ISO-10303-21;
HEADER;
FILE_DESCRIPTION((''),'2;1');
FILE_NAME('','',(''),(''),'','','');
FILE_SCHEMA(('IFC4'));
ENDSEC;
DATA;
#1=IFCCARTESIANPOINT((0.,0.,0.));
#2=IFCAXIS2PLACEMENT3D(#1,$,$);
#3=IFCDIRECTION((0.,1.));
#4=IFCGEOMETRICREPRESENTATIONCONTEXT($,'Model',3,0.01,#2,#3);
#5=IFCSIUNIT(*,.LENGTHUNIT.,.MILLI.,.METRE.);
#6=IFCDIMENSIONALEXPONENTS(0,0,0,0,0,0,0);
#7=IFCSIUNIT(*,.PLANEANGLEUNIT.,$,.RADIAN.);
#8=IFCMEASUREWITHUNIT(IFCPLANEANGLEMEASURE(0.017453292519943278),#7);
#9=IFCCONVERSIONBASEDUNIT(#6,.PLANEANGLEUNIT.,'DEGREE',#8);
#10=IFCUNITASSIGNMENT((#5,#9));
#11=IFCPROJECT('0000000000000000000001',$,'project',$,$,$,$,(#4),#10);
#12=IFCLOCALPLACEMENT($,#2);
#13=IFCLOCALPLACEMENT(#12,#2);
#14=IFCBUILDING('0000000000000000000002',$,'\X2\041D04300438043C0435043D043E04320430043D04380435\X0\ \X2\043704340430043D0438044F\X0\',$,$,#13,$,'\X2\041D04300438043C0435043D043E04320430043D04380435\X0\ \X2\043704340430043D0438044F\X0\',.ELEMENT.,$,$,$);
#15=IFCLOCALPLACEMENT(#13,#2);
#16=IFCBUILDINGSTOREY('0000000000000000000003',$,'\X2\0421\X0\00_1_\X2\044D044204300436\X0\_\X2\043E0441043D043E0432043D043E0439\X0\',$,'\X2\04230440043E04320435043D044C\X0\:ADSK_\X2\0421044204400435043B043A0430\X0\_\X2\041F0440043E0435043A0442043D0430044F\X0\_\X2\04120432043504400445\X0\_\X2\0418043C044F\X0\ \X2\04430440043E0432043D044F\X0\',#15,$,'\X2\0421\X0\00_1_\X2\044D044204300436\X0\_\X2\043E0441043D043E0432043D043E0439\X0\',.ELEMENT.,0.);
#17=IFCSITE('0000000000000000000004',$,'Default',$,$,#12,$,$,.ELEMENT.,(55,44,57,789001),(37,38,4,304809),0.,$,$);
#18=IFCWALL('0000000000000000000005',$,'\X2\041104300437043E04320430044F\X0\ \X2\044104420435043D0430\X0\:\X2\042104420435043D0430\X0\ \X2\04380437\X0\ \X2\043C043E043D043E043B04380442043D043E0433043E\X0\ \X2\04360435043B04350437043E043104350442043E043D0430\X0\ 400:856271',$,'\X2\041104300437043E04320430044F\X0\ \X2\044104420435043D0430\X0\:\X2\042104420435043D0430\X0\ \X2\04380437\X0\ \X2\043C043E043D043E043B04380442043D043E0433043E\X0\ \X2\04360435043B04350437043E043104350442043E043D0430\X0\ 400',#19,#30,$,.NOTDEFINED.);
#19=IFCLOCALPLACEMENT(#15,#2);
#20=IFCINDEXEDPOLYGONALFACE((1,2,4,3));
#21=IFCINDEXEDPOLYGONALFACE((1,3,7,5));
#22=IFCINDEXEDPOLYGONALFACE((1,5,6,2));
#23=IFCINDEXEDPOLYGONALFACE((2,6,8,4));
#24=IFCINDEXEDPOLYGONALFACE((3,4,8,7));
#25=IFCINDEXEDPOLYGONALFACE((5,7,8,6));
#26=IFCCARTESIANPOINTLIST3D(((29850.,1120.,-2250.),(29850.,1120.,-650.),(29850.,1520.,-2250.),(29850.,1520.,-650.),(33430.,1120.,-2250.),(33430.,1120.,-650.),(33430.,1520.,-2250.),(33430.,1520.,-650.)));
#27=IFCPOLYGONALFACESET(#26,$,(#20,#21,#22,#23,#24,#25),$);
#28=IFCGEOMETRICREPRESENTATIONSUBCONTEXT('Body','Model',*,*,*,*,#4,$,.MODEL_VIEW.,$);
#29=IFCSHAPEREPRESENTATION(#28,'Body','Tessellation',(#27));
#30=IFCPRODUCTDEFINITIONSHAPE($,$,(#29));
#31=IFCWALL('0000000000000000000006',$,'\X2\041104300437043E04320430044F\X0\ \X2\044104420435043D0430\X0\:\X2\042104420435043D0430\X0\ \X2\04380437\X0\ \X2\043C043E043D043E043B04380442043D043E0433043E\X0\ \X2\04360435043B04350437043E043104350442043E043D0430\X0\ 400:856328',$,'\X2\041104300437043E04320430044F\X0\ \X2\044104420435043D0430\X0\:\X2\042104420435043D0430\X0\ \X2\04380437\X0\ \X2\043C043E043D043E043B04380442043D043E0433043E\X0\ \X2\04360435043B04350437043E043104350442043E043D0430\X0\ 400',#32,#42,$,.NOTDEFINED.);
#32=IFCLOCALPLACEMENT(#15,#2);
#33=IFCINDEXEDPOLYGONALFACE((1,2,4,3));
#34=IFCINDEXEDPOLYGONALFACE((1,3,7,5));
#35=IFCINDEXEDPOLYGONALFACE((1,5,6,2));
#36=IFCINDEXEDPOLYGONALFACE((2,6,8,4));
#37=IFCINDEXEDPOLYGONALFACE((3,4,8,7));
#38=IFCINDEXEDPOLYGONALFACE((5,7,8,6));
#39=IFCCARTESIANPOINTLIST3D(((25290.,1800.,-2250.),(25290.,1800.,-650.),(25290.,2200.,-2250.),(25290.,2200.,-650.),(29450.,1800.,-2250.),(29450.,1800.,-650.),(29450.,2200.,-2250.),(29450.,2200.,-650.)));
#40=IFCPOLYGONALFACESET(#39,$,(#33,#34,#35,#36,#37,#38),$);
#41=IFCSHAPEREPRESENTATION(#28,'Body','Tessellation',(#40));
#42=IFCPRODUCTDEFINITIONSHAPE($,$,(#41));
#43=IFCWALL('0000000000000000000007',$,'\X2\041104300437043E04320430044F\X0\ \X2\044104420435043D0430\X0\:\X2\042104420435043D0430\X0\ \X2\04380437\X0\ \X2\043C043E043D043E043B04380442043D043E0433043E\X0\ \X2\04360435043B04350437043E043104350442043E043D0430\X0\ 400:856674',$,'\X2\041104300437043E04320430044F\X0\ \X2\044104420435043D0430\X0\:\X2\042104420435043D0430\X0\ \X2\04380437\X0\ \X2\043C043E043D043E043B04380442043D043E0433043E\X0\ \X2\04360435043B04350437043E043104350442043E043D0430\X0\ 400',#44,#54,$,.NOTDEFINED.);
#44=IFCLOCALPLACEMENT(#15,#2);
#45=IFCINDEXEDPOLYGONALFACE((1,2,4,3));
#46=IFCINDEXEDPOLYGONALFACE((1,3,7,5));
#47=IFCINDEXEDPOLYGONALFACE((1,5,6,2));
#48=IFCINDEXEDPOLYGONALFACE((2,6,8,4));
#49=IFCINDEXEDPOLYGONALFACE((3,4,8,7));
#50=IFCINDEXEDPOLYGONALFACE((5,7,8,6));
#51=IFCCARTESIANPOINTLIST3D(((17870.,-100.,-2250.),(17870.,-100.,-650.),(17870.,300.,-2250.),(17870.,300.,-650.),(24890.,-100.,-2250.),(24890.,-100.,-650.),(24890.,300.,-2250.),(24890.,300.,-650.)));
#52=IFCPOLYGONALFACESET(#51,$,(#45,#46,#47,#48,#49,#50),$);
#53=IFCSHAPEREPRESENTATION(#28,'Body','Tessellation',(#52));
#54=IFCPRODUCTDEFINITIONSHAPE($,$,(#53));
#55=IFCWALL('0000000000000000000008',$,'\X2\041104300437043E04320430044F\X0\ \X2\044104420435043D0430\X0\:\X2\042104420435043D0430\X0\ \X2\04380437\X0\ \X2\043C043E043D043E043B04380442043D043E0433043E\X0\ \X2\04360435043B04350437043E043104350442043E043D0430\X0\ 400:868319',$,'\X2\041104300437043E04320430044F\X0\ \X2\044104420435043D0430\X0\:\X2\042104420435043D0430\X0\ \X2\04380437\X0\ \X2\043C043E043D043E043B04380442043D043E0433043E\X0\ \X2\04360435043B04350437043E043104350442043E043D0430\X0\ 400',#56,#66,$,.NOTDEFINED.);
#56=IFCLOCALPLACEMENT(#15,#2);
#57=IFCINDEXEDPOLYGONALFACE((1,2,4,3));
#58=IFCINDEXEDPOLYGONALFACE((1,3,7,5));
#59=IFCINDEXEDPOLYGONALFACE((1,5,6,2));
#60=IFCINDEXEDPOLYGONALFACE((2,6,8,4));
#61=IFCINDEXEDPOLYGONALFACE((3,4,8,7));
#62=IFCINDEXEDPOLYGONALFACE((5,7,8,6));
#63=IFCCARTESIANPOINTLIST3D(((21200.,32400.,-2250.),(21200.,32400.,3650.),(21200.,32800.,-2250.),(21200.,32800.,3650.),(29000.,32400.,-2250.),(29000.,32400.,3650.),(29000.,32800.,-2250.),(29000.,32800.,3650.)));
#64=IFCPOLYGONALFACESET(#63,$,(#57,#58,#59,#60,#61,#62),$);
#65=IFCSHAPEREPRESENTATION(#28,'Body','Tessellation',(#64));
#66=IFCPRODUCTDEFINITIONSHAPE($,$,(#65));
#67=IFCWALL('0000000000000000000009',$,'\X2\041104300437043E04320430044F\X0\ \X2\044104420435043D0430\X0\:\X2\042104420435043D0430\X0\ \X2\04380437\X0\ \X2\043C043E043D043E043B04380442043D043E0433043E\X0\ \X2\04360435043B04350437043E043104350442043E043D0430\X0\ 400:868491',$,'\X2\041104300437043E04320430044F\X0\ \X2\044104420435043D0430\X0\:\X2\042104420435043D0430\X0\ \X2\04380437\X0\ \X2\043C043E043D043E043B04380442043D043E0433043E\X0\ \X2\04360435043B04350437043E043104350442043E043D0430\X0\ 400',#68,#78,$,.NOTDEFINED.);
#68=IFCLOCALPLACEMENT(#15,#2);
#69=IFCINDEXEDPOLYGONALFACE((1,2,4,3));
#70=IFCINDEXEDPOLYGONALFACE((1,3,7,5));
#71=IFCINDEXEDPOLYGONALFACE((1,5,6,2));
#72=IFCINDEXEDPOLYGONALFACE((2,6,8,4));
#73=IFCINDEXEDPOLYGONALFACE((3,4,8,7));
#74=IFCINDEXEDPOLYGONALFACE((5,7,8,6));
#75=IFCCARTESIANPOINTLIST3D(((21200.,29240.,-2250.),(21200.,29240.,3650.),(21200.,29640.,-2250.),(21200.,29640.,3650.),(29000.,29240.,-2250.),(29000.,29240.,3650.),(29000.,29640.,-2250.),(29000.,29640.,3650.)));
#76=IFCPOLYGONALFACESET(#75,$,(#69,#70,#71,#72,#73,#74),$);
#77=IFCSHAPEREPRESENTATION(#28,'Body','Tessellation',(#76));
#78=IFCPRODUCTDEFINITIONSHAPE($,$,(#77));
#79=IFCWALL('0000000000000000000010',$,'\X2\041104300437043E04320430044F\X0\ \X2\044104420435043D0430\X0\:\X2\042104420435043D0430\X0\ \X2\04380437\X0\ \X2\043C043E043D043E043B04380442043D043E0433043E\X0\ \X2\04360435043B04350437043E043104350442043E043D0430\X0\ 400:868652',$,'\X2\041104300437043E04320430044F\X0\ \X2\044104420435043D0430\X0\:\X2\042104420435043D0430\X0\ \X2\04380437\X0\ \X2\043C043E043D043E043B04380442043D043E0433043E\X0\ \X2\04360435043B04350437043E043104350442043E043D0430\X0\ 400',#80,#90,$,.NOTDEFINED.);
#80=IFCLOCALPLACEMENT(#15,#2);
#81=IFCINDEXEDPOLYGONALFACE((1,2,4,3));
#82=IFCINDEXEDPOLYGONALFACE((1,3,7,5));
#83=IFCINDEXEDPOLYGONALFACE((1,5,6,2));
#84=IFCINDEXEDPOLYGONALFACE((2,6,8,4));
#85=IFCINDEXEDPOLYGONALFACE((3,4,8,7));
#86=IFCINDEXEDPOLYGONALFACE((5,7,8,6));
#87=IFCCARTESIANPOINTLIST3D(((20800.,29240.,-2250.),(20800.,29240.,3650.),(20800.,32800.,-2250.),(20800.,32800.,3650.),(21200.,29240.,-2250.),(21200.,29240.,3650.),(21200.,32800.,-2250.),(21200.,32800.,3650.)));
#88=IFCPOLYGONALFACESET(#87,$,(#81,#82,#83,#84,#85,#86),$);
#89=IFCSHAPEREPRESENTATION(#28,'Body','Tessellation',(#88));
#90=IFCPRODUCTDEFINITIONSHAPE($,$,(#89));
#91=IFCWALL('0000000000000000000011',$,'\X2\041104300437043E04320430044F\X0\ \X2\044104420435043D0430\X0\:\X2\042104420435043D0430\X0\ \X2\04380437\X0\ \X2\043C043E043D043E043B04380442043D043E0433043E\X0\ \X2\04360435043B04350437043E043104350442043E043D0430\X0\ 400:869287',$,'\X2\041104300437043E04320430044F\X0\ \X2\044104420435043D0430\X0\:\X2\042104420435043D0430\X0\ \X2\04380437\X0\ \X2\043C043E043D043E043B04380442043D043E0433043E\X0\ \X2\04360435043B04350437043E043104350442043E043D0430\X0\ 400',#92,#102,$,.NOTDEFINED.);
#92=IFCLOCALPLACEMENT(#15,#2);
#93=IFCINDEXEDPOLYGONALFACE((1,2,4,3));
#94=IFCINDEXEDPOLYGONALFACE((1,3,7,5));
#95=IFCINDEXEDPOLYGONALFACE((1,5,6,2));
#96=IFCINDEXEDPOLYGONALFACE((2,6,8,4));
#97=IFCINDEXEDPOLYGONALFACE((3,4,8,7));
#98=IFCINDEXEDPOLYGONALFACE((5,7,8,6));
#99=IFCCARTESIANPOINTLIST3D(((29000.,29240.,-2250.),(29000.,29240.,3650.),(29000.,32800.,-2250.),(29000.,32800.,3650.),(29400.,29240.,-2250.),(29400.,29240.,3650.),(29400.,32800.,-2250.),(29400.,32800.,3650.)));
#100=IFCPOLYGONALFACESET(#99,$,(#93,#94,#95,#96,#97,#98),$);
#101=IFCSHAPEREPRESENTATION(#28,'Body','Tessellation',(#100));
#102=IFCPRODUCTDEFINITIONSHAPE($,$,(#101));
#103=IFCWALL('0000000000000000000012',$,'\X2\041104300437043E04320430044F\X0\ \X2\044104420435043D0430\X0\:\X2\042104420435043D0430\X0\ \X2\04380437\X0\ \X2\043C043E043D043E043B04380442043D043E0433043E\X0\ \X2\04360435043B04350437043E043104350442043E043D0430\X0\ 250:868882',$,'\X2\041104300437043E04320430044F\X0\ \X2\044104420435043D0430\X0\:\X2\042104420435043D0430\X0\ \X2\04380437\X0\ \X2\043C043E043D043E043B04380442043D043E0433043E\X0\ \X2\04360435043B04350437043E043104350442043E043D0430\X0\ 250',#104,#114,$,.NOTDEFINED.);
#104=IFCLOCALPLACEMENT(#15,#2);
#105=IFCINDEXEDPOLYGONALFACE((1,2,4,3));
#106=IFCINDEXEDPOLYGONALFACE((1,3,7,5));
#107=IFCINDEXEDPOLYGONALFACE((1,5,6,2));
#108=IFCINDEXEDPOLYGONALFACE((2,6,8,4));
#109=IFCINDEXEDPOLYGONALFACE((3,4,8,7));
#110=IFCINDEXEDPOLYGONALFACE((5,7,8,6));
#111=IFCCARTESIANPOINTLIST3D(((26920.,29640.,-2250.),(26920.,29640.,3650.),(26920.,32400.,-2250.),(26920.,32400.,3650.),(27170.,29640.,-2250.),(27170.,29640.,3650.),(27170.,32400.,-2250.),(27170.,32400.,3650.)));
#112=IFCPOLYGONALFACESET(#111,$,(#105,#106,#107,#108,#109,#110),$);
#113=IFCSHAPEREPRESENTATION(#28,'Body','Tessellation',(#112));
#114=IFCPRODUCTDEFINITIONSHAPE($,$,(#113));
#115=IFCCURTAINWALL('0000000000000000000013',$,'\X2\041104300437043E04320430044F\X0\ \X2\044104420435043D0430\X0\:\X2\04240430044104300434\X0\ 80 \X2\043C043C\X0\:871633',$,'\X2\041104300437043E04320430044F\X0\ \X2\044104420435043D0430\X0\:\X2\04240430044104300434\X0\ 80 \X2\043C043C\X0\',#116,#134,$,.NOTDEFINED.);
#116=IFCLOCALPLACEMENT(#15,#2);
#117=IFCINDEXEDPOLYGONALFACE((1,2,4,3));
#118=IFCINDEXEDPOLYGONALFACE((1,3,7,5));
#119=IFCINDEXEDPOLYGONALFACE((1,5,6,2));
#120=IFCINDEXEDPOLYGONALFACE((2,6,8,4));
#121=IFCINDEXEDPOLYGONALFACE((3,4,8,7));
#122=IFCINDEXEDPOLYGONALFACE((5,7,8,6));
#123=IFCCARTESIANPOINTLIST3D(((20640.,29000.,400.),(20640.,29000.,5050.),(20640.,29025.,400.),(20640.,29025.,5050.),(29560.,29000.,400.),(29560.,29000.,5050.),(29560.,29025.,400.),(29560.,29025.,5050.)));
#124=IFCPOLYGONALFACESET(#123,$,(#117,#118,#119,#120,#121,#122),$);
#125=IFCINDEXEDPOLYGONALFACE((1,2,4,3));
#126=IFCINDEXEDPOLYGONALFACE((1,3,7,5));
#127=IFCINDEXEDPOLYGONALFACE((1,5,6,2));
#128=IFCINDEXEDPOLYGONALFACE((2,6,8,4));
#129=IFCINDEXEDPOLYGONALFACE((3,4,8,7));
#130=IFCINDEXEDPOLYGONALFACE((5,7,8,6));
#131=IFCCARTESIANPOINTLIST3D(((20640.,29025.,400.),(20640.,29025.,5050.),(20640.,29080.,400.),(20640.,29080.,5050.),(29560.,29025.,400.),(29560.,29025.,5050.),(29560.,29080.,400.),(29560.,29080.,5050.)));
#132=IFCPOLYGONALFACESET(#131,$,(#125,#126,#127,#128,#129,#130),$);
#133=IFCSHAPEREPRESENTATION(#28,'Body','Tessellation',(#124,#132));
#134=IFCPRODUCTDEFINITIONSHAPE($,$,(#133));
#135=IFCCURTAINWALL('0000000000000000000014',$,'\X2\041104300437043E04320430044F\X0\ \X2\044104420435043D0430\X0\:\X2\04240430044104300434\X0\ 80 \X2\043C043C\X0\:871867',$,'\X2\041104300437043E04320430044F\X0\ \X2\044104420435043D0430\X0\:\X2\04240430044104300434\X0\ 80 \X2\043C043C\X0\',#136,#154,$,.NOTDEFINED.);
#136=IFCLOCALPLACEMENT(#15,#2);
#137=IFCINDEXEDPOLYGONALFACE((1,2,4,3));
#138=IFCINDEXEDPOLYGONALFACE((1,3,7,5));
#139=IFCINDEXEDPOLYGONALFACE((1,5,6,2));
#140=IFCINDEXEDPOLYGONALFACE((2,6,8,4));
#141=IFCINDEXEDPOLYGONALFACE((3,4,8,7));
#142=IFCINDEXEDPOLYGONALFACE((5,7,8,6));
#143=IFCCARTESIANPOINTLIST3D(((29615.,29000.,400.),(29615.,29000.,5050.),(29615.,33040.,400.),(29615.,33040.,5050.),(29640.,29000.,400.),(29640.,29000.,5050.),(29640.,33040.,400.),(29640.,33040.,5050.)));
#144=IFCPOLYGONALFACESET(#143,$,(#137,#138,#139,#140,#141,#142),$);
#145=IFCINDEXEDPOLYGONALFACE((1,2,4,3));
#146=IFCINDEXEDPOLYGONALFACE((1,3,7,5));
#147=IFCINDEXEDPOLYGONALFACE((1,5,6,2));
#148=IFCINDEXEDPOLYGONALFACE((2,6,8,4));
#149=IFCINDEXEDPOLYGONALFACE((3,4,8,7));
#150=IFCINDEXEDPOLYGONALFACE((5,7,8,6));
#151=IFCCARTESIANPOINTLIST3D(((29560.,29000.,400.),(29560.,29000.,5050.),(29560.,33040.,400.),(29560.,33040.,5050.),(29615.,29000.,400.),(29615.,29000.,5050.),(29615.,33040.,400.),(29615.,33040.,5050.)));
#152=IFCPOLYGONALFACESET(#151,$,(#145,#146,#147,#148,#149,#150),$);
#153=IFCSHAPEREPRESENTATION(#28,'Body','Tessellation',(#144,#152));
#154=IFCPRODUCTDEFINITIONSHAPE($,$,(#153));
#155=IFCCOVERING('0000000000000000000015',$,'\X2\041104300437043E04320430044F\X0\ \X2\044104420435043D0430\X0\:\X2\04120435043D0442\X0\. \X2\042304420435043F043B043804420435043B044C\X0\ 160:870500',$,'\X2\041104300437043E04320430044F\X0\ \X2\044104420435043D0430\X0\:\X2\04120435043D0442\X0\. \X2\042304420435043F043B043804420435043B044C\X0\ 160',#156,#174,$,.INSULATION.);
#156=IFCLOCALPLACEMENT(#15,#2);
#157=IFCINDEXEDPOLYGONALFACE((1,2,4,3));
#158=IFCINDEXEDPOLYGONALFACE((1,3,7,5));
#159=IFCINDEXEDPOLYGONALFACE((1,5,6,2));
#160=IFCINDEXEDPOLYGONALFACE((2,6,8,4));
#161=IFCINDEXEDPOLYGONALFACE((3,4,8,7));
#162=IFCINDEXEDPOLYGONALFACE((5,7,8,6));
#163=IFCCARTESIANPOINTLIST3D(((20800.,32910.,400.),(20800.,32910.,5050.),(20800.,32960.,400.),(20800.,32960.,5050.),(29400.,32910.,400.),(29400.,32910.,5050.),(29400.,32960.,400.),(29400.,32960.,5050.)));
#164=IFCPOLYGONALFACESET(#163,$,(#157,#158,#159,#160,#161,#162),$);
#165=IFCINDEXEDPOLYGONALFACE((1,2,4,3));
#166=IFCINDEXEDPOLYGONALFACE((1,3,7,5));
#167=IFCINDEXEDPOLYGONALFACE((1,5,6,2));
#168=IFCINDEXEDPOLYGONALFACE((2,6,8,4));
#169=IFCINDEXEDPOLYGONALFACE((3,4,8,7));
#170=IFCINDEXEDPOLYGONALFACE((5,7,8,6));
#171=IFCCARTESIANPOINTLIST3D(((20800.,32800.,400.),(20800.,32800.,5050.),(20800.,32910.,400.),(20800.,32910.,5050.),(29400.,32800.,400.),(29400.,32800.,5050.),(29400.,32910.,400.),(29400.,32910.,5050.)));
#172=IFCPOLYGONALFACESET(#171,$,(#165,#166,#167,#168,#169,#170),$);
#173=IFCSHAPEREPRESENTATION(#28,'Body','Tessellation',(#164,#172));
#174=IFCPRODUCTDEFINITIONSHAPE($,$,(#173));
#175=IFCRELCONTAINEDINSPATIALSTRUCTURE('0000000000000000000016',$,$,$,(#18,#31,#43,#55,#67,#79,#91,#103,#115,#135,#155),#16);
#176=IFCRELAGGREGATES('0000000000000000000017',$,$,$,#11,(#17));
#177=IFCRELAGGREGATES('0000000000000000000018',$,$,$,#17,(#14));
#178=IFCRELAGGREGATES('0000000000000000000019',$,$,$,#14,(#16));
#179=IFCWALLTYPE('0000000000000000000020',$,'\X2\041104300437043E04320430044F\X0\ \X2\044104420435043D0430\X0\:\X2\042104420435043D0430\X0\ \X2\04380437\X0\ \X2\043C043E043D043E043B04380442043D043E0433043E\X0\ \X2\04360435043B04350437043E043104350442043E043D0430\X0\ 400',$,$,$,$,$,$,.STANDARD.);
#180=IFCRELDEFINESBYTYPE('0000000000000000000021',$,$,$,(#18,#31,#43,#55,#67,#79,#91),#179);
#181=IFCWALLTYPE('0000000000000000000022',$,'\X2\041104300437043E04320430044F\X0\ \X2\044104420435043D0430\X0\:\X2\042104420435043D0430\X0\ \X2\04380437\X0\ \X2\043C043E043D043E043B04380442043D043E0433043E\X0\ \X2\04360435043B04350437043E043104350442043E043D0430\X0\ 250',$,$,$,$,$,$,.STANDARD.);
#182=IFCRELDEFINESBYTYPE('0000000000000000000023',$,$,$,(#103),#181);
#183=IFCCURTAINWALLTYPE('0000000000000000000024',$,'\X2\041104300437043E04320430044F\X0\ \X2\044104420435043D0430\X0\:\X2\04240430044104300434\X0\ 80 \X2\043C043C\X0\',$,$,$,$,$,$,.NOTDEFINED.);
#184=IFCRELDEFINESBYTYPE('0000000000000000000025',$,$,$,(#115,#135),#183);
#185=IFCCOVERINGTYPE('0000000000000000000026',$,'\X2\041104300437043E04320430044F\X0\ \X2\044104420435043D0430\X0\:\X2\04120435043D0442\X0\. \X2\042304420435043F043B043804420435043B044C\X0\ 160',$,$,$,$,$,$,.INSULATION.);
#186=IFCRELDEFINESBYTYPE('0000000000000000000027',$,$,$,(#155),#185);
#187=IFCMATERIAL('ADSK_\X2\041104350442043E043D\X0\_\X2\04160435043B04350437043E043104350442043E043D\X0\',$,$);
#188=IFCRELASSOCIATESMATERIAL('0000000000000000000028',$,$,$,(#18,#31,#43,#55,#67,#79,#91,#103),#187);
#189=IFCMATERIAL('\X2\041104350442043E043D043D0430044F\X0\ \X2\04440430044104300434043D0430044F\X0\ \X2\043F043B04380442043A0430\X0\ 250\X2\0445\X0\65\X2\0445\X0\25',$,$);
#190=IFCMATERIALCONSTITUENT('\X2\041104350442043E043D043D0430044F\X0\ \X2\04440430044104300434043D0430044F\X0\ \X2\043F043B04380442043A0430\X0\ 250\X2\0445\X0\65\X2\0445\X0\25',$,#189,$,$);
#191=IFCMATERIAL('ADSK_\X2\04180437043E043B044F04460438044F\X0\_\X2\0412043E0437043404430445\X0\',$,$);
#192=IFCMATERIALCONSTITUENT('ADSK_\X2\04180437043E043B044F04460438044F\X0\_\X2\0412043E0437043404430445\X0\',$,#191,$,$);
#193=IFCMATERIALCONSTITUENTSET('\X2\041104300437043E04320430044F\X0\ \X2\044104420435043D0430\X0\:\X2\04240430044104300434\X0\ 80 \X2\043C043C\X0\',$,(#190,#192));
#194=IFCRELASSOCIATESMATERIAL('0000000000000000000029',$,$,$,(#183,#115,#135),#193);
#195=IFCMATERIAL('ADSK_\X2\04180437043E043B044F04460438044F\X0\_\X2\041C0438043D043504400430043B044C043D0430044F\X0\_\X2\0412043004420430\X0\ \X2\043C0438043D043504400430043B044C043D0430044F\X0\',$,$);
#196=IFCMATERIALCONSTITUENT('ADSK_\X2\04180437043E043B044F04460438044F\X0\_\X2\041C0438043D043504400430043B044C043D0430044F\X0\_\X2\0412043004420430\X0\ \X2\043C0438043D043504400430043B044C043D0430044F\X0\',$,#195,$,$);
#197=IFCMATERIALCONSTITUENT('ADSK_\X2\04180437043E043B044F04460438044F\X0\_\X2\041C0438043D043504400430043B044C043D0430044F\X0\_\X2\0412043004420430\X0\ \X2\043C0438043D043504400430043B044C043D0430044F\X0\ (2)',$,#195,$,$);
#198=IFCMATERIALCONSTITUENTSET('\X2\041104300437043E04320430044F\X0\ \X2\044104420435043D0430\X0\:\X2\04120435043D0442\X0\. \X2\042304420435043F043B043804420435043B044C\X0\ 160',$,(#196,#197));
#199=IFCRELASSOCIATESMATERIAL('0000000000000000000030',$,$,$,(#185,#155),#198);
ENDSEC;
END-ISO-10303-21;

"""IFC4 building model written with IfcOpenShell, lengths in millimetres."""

from ifc_helpers import new_model, entity, si_unit, converted_unit, direction, frame, origin, place, context, subcontext, project, spatial, indexed_curve, outline, extrude, material, constituent, constituent_set, type_object, element, save


model = new_model("IFC4")

# Units and contexts
model_context = context("Model", 3, precision=0.01, world=origin(), true_north=direction((0.0, 1.0)))
body_context = subcontext(model_context, "Body", "Model", "MODEL_VIEW")
ifc_project = project(units=[si_unit("LENGTHUNIT", "METRE", prefix="MILLI"), converted_unit("PLANEANGLEUNIT", "DEGREE", entity("IfcPlaneAngleMeasure", 0.017453292519943278), si_unit("PLANEANGLEUNIT", "RADIAN"), dimensions=[0, 0, 0, 0, 0, 0, 0])], contexts=[model_context])

# Site, building, storey
site_placement = place(None, origin())
site = spatial("IfcSite", under=ifc_project, at=site_placement, Name="Default", CompositionType="ELEMENT", RefLatitude=(55, 44, 57, 789001), RefLongitude=(37, 38, 4, 304809), RefElevation=0.0)
building_placement = place(site_placement, origin())
building = spatial("IfcBuilding", under=site, at=building_placement, Name="Наименование здания", LongName="Наименование здания", CompositionType="ELEMENT")
storey_placement = place(building_placement, origin())
storey = spatial("IfcBuildingStorey", under=building, at=storey_placement, Name="С00_1_этаж_основной", ObjectType="Уровень:ADSK_Стрелка_Проектная_Вверх_Имя уровня", LongName="С00_1_этаж_основной", CompositionType="ELEMENT", Elevation=0.0)

# Walls
ifc_material_1 = material(Name="ADSK_Бетон_Железобетон")
wall_type_1 = type_object("IfcWallType", Name="Базовая стена:Стена из монолитного железобетона 400", PredefinedType="STANDARD")
wall_1_placement = place(storey_placement, frame((33430.0, 1320.0, -2250.0), z_axis=(0.0, 0.0, 1.0), x_axis=(-1.0, 0.0, 0.0)))
element("IfcWall", 1, at=wall_1_placement, inside=storey, type_object=wall_type_1, material=ifc_material_1, Name="Базовая стена:Стена из монолитного железобетона 400:856271", ObjectType="Базовая стена:Стена из монолитного железобетона 400", PredefinedType="NOTDEFINED", context=body_context, shape_type="SweptSolid", body=[
    extrude(outline(indexed_curve([(3580.0, 200.0), (0.0, 200.0), (0.0, -200.0), (3580.0, -200.0), (3580.0, 200.0)], self_intersect=False)), origin(), (0.0, 0.0, 1.0), 1600.0),
])
wall_2_placement = place(storey_placement, frame((29450.0, 2000.0, -2250.0), z_axis=(0.0, 0.0, 1.0), x_axis=(-1.0, 0.0, 0.0)))
element("IfcWall", 2, at=wall_2_placement, inside=storey, type_object=wall_type_1, material=ifc_material_1, Name="Базовая стена:Стена из монолитного железобетона 400:856328", ObjectType="Базовая стена:Стена из монолитного железобетона 400", PredefinedType="NOTDEFINED", context=body_context, shape_type="SweptSolid", body=[
    extrude(outline(indexed_curve([(4160.0, 200.0), (0.0, 200.0), (0.0, -200.0), (4160.0, -200.0), (4160.0, 200.0)], self_intersect=False)), origin(), (0.0, 0.0, 1.0), 1600.0),
])
wall_3_placement = place(storey_placement, frame((24890.0, 100.0, -2250.0), z_axis=(0.0, 0.0, 1.0), x_axis=(-1.0, 0.0, 0.0)))
element("IfcWall", 3, at=wall_3_placement, inside=storey, type_object=wall_type_1, material=ifc_material_1, Name="Базовая стена:Стена из монолитного железобетона 400:856674", ObjectType="Базовая стена:Стена из монолитного железобетона 400", PredefinedType="NOTDEFINED", context=body_context, shape_type="SweptSolid", body=[
    extrude(outline(indexed_curve([(7020.0, 200.0), (0.0, 200.0), (0.0, -200.0), (7020.0, -200.0), (7020.0, 200.0)], self_intersect=False)), origin(), (0.0, 0.0, 1.0), 1600.0),
])
wall_4_placement = place(storey_placement, frame((21200.0, 32600.0, -2250.0)))
element("IfcWall", 4, at=wall_4_placement, inside=storey, type_object=wall_type_1, material=ifc_material_1, Name="Базовая стена:Стена из монолитного железобетона 400:868319", ObjectType="Базовая стена:Стена из монолитного железобетона 400", PredefinedType="NOTDEFINED", context=body_context, shape_type="SweptSolid", body=[
    extrude(outline(indexed_curve([(7800.0, 200.0), (0.0, 200.0), (0.0, -200.0), (7800.0, -200.0), (7800.0, 200.0)], self_intersect=False)), origin(), (0.0, 0.0, 1.0), 5900.0),
])
wall_5_placement = place(storey_placement, frame((21200.0, 29440.0, -2250.0)))
element("IfcWall", 5, at=wall_5_placement, inside=storey, type_object=wall_type_1, material=ifc_material_1, Name="Базовая стена:Стена из монолитного железобетона 400:868491", ObjectType="Базовая стена:Стена из монолитного железобетона 400", PredefinedType="NOTDEFINED", context=body_context, shape_type="SweptSolid", body=[
    extrude(outline(indexed_curve([(7800.0, 200.0), (0.0, 200.0), (0.0, -200.0), (7800.0, -200.0), (7800.0, 200.0)], self_intersect=False)), origin(), (0.0, 0.0, 1.0), 5900.0),
])
wall_6_placement = place(storey_placement, frame((21000.0, 32800.0, -2250.0), z_axis=(0.0, 0.0, 1.0), x_axis=(0.0, -1.0, 0.0)))
element("IfcWall", 6, at=wall_6_placement, inside=storey, type_object=wall_type_1, material=ifc_material_1, Name="Базовая стена:Стена из монолитного железобетона 400:868652", ObjectType="Базовая стена:Стена из монолитного железобетона 400", PredefinedType="NOTDEFINED", context=body_context, shape_type="SweptSolid", body=[
    extrude(outline(indexed_curve([(3560.0, 200.0), (0.0, 200.0), (0.0, -200.0), (3560.0, -200.0), (3560.0, 200.0)], self_intersect=False)), origin(), (0.0, 0.0, 1.0), 5900.0),
])
wall_7_placement = place(storey_placement, frame((29200.0, 32800.0, -2250.0), z_axis=(0.0, 0.0, 1.0), x_axis=(0.0, -1.0, 0.0)))
element("IfcWall", 7, at=wall_7_placement, inside=storey, type_object=wall_type_1, material=ifc_material_1, Name="Базовая стена:Стена из монолитного железобетона 400:869287", ObjectType="Базовая стена:Стена из монолитного железобетона 400", PredefinedType="NOTDEFINED", context=body_context, shape_type="SweptSolid", body=[
    extrude(outline(indexed_curve([(3560.0, 200.0), (0.0, 200.0), (0.0, -200.0), (3560.0, -200.0), (3560.0, 200.0)], self_intersect=False)), origin(), (0.0, 0.0, 1.0), 5900.0),
])
wall_type_2 = type_object("IfcWallType", Name="Базовая стена:Стена из монолитного железобетона 250", PredefinedType="STANDARD")
wall_8_placement = place(storey_placement, frame((27045.0, 29640.0, -2250.0), z_axis=(0.0, 0.0, 1.0), x_axis=(0.0, 1.0, 0.0)))
element("IfcWall", 8, at=wall_8_placement, inside=storey, type_object=wall_type_2, material=ifc_material_1, Name="Базовая стена:Стена из монолитного железобетона 250:868882", ObjectType="Базовая стена:Стена из монолитного железобетона 250", PredefinedType="NOTDEFINED", context=body_context, shape_type="SweptSolid", body=[
    extrude(outline(indexed_curve([(2760.0, 125.0), (0.0, 125.0), (0.0, -125.0), (2760.0, -125.0), (2760.0, 125.0)], self_intersect=False)), origin(), (0.0, 0.0, 1.0), 5900.0),
])

# Curtain walls
ifc_material_2 = material(Name="Бетонная фасадная плитка 250х65х25")
ifc_constituent_1 = constituent(ifc_material_2, Name="Бетонная фасадная плитка 250х65х25")
ifc_material_3 = material(Name="ADSK_Изоляция_Воздух")
ifc_constituent_2 = constituent(ifc_material_3, Name="ADSK_Изоляция_Воздух")
ifc_constituent_set_1 = constituent_set(constituents=[ifc_constituent_1, ifc_constituent_2], Name="Базовая стена:Фасад 80 мм")
curtain_wall_type = type_object("IfcCurtainWallType", Name="Базовая стена:Фасад 80 мм", PredefinedType="NOTDEFINED", material=ifc_constituent_set_1)
curtain_wall_1_placement = place(storey_placement, frame((29560.0, 29040.0, 400.0), z_axis=(0.0, 0.0, 1.0), x_axis=(-1.0, 0.0, 0.0)))
element("IfcCurtainWall", 9, at=curtain_wall_1_placement, inside=storey, type_object=curtain_wall_type, material=ifc_constituent_set_1, Name="Базовая стена:Фасад 80 мм:871633", ObjectType="Базовая стена:Фасад 80 мм", PredefinedType="NOTDEFINED", context=body_context, shape_type="SweptSolid", body=[
    extrude(outline(indexed_curve([(-12.5, -4460.0), (12.5, -4460.0), (12.5, 4460.0), (-12.5, 4460.0), (-12.5, -4460.0)], self_intersect=False)), frame((4460.0, 27.5, 0.0), z_axis=(0.0, 0.0, 1.0), x_axis=(0.0, -1.0, 0.0)), (0.0, 0.0, 1.0), 4650.0),
    extrude(outline(indexed_curve([(-27.5, -4460.0), (27.5, -4460.0), (27.5, 4460.0), (-27.5, 4460.0), (-27.5, -4460.0)], self_intersect=False)), frame((4460.0, -12.5, 0.0), z_axis=(0.0, 0.0, 1.0), x_axis=(0.0, 1.0, 0.0)), (0.0, 0.0, 1.0), 4650.0),
])
curtain_wall_2_placement = place(storey_placement, frame((29600.0, 33040.0, 400.0), z_axis=(0.0, 0.0, 1.0), x_axis=(0.0, -1.0, 0.0)))
element("IfcCurtainWall", 10, at=curtain_wall_2_placement, inside=storey, type_object=curtain_wall_type, material=ifc_constituent_set_1, Name="Базовая стена:Фасад 80 мм:871867", ObjectType="Базовая стена:Фасад 80 мм", PredefinedType="NOTDEFINED", context=body_context, shape_type="SweptSolid", body=[
    extrude(outline(indexed_curve([(-12.5, -2020.0), (12.5, -2020.0), (12.5, 2020.0), (-12.5, 2020.0), (-12.5, -2020.0)], self_intersect=False)), frame((2020.0, 27.5, 0.0), z_axis=(0.0, 0.0, 1.0), x_axis=(0.0, -1.0, 0.0)), (0.0, 0.0, 1.0), 4650.0),
    extrude(outline(indexed_curve([(-27.5, -2020.0), (27.5, -2020.0), (27.5, 2020.0), (-27.5, 2020.0), (-27.5, -2020.0)], self_intersect=False)), frame((2020.0, -12.5, 0.0), z_axis=(0.0, 0.0, 1.0), x_axis=(0.0, 1.0, 0.0)), (0.0, 0.0, 1.0), 4650.0),
])

# Covering
ifc_material_4 = material(Name="ADSK_Изоляция_Минеральная_Вата минеральная")
ifc_constituent_3 = constituent(ifc_material_4, Name="ADSK_Изоляция_Минеральная_Вата минеральная")
ifc_constituent_4 = constituent(ifc_material_4, Name="ADSK_Изоляция_Минеральная_Вата минеральная (2)")
ifc_constituent_set_2 = constituent_set(constituents=[ifc_constituent_3, ifc_constituent_4], Name="Базовая стена:Вент. Утеплитель 160")
covering_type = type_object("IfcCoveringType", Name="Базовая стена:Вент. Утеплитель 160", PredefinedType="INSULATION", material=ifc_constituent_set_2)
covering_1_placement = place(storey_placement, frame((20800.0, 32880.0, 400.0)))
element("IfcCovering", 11, at=covering_1_placement, inside=storey, type_object=covering_type, material=ifc_constituent_set_2, Name="Базовая стена:Вент. Утеплитель 160:870500", ObjectType="Базовая стена:Вент. Утеплитель 160", PredefinedType="INSULATION", context=body_context, shape_type="SweptSolid", body=[
    extrude(outline(indexed_curve([(-25.0, -4300.0), (25.0, -4300.0), (25.0, 4300.0), (-25.0, 4300.0), (-25.0, -4300.0)], self_intersect=False)), frame((4300.0, 55.0, 0.0), z_axis=(0.0, 0.0, 1.0), x_axis=(0.0, -1.0, 0.0)), (0.0, 0.0, 1.0), 4650.0),
    extrude(outline(indexed_curve([(-55.0, -4300.0), (55.0, -4300.0), (55.0, 4300.0), (-55.0, 4300.0), (-55.0, -4300.0)], self_intersect=False)), frame((4300.0, -25.0, 0.0), z_axis=(0.0, 0.0, 1.0), x_axis=(0.0, 1.0, 0.0)), (0.0, 0.0, 1.0), 4650.0),
])

save(model, "model.ifc")
